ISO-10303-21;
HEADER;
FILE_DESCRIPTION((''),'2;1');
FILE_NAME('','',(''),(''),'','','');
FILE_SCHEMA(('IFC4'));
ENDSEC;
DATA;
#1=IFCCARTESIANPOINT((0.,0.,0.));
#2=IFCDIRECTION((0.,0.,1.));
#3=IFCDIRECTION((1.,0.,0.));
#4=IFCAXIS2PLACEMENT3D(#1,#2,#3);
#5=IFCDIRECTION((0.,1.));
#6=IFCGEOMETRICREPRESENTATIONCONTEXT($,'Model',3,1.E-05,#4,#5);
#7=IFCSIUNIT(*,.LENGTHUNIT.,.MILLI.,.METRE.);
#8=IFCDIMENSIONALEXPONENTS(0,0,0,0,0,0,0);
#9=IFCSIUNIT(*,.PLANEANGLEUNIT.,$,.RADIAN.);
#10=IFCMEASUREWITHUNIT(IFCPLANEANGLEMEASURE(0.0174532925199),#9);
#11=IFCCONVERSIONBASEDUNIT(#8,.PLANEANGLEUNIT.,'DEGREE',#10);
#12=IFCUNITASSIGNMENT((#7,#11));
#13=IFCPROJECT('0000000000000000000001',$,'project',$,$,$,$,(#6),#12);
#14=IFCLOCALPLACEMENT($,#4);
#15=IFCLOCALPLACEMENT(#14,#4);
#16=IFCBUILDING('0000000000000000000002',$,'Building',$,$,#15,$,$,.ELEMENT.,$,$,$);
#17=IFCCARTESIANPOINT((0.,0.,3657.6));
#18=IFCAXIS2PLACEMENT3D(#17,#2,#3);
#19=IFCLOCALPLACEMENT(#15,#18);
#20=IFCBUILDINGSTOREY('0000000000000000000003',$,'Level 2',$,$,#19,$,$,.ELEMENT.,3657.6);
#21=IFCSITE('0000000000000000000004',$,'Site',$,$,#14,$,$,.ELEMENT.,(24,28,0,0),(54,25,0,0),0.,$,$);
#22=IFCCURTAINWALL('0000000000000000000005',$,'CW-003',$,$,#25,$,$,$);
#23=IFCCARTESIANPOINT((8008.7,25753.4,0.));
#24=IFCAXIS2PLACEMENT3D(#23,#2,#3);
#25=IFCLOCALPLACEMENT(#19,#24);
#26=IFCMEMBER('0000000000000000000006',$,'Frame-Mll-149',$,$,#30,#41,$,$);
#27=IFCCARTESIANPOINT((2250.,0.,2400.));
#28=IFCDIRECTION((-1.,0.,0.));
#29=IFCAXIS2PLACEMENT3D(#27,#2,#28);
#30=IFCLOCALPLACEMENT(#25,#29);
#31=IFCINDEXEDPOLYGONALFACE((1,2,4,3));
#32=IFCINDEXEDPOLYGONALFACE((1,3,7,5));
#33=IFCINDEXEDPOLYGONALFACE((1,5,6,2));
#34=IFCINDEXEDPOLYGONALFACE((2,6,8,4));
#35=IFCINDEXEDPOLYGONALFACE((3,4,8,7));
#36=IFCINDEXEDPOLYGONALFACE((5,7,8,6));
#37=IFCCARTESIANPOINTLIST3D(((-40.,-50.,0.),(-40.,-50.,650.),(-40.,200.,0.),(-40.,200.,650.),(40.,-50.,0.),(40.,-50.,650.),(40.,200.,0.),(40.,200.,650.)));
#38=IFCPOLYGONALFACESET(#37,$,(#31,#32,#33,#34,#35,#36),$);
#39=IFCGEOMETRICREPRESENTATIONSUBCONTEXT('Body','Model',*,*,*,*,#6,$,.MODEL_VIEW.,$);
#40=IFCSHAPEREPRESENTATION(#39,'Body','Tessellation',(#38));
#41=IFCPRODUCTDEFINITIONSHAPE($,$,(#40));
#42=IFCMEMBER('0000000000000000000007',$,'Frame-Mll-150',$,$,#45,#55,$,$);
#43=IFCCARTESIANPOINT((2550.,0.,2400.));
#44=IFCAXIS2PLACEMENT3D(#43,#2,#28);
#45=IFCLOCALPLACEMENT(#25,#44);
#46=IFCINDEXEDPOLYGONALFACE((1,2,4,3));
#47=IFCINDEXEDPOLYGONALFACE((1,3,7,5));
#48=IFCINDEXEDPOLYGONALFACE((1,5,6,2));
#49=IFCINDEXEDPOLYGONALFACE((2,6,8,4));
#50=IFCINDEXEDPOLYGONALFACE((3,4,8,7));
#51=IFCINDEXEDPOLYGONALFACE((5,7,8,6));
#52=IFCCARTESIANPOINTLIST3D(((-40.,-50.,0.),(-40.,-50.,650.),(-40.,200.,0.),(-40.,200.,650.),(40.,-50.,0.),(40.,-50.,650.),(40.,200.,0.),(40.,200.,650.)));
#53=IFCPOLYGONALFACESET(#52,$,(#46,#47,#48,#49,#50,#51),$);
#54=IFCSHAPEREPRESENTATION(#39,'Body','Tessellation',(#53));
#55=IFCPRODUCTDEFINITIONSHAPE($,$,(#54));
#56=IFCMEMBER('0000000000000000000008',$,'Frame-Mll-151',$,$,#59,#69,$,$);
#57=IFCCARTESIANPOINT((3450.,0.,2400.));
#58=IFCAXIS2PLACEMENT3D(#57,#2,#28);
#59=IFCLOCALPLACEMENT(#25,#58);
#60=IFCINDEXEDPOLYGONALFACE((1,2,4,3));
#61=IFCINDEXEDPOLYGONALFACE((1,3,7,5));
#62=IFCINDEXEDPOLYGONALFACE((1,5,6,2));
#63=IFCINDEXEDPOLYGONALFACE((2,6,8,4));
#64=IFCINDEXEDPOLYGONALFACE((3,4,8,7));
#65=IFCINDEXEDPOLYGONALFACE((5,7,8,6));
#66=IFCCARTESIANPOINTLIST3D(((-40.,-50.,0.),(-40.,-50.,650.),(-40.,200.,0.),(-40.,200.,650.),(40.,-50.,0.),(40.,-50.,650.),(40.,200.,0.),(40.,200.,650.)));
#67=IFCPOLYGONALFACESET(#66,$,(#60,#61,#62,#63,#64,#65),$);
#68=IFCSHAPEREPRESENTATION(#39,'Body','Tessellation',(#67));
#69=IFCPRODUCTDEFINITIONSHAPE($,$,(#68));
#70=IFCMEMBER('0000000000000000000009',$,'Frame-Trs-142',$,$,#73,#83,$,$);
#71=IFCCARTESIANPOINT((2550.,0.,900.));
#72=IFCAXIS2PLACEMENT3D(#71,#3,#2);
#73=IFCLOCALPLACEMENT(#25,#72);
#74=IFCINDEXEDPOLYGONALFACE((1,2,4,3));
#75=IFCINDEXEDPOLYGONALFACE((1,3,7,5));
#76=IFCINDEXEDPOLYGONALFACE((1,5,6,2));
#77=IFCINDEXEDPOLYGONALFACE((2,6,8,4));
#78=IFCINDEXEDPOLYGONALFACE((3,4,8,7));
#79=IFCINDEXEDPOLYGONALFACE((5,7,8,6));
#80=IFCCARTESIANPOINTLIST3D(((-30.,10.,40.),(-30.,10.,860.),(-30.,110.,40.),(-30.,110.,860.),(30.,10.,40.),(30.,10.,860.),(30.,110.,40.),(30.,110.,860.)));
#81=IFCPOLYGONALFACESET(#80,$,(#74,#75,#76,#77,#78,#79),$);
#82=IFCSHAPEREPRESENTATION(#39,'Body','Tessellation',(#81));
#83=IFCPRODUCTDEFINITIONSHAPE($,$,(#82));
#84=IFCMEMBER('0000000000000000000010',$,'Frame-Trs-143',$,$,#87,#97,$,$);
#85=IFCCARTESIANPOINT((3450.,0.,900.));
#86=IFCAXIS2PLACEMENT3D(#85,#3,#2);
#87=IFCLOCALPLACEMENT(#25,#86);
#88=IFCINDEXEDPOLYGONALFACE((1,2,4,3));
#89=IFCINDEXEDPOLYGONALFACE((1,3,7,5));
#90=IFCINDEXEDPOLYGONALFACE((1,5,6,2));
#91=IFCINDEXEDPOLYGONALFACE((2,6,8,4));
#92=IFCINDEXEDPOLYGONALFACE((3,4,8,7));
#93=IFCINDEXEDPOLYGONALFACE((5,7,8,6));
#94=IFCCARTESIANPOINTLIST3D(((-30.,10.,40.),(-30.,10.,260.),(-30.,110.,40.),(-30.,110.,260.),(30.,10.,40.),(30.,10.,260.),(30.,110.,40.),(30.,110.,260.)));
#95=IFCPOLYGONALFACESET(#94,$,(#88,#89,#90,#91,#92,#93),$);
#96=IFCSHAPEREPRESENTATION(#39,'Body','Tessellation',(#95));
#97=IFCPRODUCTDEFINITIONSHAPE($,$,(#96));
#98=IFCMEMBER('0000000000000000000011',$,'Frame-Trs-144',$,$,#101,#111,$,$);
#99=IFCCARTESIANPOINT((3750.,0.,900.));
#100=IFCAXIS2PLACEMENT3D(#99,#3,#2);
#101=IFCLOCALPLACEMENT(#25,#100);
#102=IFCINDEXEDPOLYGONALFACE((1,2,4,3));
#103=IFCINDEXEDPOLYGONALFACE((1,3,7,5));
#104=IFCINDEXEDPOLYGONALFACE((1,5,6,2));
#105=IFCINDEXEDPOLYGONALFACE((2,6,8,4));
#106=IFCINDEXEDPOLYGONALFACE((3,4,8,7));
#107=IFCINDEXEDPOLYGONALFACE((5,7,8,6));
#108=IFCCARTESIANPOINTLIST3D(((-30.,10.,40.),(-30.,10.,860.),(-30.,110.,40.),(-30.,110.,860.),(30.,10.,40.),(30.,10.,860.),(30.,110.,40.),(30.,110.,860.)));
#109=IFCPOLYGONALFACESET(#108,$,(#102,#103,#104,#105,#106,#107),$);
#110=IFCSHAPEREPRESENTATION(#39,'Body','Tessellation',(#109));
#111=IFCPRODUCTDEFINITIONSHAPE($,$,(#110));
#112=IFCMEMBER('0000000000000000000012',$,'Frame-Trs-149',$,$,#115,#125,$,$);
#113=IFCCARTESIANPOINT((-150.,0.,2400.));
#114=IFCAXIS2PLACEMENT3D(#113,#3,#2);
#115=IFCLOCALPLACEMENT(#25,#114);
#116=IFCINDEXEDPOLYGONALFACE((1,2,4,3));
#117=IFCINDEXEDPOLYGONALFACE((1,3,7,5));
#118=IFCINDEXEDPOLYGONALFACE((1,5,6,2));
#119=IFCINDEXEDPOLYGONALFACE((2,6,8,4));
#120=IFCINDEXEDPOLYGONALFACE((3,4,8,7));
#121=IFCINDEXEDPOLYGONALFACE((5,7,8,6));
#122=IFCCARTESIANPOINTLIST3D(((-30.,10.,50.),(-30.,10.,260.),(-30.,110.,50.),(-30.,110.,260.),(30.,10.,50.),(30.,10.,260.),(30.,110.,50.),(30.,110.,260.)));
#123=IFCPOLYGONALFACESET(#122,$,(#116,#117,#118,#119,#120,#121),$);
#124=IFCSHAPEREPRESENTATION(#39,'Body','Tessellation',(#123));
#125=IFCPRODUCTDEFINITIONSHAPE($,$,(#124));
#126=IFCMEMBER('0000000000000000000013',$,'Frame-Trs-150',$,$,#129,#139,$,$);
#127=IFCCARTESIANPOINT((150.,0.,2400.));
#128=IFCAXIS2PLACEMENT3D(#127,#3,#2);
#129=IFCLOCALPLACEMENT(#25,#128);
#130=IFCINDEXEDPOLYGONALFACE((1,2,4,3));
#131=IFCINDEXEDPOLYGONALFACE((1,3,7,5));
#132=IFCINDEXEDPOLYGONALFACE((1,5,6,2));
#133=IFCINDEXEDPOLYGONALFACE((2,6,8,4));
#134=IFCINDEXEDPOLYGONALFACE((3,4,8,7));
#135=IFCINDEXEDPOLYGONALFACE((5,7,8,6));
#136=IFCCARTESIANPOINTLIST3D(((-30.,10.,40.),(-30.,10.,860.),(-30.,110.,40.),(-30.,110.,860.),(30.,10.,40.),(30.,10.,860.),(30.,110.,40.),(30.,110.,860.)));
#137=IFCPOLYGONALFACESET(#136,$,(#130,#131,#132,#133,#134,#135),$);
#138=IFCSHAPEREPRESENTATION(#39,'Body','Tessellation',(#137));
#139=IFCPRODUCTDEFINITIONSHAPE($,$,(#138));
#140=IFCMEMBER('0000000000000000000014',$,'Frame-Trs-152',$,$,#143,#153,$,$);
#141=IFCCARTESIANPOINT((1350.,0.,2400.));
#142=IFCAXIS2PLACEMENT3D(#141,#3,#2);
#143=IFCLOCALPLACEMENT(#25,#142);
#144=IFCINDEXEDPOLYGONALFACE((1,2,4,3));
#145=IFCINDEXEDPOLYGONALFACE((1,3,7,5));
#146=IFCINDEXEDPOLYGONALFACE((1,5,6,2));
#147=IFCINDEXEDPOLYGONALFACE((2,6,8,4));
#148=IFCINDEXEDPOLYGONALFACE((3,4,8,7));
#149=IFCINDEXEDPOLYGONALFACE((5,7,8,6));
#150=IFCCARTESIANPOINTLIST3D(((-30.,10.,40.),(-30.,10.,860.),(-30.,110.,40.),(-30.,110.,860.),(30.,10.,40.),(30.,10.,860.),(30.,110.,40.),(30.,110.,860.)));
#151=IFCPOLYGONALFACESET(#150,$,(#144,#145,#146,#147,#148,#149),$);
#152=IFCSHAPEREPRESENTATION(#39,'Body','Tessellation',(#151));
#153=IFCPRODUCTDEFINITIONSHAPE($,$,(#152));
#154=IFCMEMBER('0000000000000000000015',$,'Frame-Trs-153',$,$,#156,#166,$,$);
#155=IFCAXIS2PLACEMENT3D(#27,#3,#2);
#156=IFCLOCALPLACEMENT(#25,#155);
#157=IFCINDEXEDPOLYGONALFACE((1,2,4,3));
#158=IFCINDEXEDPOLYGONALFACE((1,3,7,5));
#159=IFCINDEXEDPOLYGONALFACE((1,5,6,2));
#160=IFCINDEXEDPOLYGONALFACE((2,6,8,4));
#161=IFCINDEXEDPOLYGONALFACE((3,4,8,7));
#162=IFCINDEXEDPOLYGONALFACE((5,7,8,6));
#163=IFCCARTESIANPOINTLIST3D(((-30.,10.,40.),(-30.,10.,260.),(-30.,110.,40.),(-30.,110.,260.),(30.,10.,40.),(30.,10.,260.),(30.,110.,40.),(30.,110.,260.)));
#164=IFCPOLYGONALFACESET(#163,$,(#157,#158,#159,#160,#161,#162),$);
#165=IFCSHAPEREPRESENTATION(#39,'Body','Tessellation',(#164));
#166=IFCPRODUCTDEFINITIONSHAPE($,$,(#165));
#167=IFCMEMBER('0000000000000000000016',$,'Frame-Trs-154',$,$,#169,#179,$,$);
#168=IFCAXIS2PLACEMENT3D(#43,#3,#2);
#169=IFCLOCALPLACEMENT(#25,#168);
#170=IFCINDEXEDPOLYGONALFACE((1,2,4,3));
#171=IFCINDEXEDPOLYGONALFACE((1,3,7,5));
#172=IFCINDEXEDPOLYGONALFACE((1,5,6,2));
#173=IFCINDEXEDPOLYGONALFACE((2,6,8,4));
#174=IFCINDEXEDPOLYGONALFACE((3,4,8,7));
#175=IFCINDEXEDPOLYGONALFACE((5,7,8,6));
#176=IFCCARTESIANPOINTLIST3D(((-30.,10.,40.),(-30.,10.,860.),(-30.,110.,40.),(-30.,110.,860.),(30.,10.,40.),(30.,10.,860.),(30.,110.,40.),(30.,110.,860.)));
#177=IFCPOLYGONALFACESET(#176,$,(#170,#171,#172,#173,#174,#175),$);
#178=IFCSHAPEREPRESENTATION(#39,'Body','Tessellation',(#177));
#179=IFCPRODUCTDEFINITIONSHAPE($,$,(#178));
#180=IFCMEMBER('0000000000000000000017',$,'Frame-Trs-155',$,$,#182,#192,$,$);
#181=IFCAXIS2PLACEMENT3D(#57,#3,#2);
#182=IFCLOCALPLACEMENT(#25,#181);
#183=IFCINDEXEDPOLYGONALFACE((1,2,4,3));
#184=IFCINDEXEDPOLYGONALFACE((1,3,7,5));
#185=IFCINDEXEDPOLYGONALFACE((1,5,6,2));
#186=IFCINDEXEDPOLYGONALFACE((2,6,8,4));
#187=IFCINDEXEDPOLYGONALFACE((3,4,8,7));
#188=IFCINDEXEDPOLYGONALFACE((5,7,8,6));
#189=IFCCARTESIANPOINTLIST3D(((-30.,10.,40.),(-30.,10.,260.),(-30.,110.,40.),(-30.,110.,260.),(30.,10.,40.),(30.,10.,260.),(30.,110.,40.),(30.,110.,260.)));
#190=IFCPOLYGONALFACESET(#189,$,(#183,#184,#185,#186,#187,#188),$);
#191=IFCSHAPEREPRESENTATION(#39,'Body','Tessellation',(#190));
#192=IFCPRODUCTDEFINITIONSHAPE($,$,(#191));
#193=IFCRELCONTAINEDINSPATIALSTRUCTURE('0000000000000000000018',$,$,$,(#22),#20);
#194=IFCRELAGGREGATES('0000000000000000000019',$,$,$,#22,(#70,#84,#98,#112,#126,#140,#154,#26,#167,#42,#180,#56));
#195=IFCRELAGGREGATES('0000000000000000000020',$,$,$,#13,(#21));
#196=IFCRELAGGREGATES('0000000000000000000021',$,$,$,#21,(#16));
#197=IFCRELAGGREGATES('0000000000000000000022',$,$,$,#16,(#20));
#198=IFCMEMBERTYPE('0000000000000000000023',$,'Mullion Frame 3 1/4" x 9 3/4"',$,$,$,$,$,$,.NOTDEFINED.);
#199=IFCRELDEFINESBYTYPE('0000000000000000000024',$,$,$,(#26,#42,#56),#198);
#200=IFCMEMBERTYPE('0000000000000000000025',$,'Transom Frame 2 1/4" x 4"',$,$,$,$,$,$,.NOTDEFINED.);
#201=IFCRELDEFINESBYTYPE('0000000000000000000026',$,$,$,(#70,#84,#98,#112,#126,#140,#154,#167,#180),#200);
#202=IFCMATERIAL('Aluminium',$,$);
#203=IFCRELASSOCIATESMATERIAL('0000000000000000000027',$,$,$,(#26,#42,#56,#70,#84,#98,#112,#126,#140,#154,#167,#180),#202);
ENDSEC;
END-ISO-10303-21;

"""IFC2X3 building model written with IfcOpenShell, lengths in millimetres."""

from ifc_helpers import new_model, entity, si_unit, converted_unit, direction, frame, origin_with_axes, place, context, subcontext, project, spatial, polyline, outline, extrude, material, type_object, element, aggregate, save


model = new_model("IFC2X3")

# Units and contexts
model_context = context("Model", 3, precision=1e-05, world=origin_with_axes(), true_north=direction((0.0, 1.0)))
body_context = subcontext(model_context, "Body", "Model", "MODEL_VIEW")
ifc_project = project(units=[si_unit("LENGTHUNIT", "METRE", prefix="MILLI"), converted_unit("PLANEANGLEUNIT", "DEGREE", entity("IfcPlaneAngleMeasure", 0.0174532925199), si_unit("PLANEANGLEUNIT", "RADIAN"), dimensions=[0, 0, 0, 0, 0, 0, 0])], contexts=[model_context])

# Site, building, storey
site_placement = place(None, origin_with_axes())
site = spatial("IfcSite", under=ifc_project, at=site_placement, Name="Site", CompositionType="ELEMENT", RefLatitude=(24, 28, 0, 0), RefLongitude=(54, 25, 0, 0), RefElevation=0.0)
building_placement = place(site_placement, origin_with_axes())
building = spatial("IfcBuilding", under=site, at=building_placement, Name="Building", CompositionType="ELEMENT")
storey_placement = place(building_placement, frame((0.0, 0.0, 3657.6), z_axis=(0.0, 0.0, 1.0), x_axis=(1.0, 0.0, 0.0)))
storey = spatial("IfcBuildingStorey", under=building, at=storey_placement, Name="Level 2", CompositionType="ELEMENT", Elevation=3657.6)

# Curtain wall, members
curtain_wall_placement = place(storey_placement, frame((8008.7, 25753.4, 0.0), z_axis=(0.0, 0.0, 1.0), x_axis=(1.0, 0.0, 0.0)))
curtain_wall = element("IfcCurtainWall", 1, at=curtain_wall_placement, inside=storey, Name="CW-003")
ifc_material_1 = material(Name="Aluminium")
member_type_1 = type_object("IfcMemberType", Name="Mullion Frame 3 1/4\" x 9 3/4\"", PredefinedType="NOTDEFINED")
member_1_placement = place(curtain_wall_placement, frame((2250.0, 0.0, 2400.0), z_axis=(0.0, 0.0, 1.0), x_axis=(-1.0, 0.0, 0.0)))
member_1 = element("IfcMember", 2, at=member_1_placement, type_object=member_type_1, material=ifc_material_1, Name="Frame-Mll-149", context=body_context, shape_type="SweptSolid", body=[
    extrude(outline(polyline([(-40.0, -200.0), (40.0, -200.0), (40.0, 50.0), (-40.0, 50.0), (-40.0, -200.0)])), frame((0.0, 0.0, 0.0), z_axis=(0.0, 0.0, 1.0), x_axis=(-1.0, 0.0, 0.0)), (0.0, 0.0, 1.0), 650.0),
])
member_2_placement = place(curtain_wall_placement, frame((2550.0, 0.0, 2400.0), z_axis=(0.0, 0.0, 1.0), x_axis=(-1.0, 0.0, 0.0)))
member_2 = element("IfcMember", 3, at=member_2_placement, type_object=member_type_1, material=ifc_material_1, Name="Frame-Mll-150", context=body_context, shape_type="SweptSolid", body=[
    extrude(outline(polyline([(-40.0, -200.0), (40.0, -200.0), (40.0, 50.0), (-40.0, 50.0), (-40.0, -200.0)])), frame((0.0, 0.0, 0.0), z_axis=(0.0, 0.0, 1.0), x_axis=(-1.0, 0.0, 0.0)), (0.0, 0.0, 1.0), 650.0),
])
member_3_placement = place(curtain_wall_placement, frame((3450.0, 0.0, 2400.0), z_axis=(0.0, 0.0, 1.0), x_axis=(-1.0, 0.0, 0.0)))
member_3 = element("IfcMember", 4, at=member_3_placement, type_object=member_type_1, material=ifc_material_1, Name="Frame-Mll-151", context=body_context, shape_type="SweptSolid", body=[
    extrude(outline(polyline([(-40.0, -200.0), (40.0, -200.0), (40.0, 50.0), (-40.0, 50.0), (-40.0, -200.0)])), frame((0.0, 0.0, 0.0), z_axis=(0.0, 0.0, 1.0), x_axis=(-1.0, 0.0, 0.0)), (0.0, 0.0, 1.0), 650.0),
])
member_type_2 = type_object("IfcMemberType", Name="Transom Frame 2 1/4\" x 4\"", PredefinedType="NOTDEFINED")
member_4_placement = place(curtain_wall_placement, frame((2550.0, 0.0, 900.0), z_axis=(1.0, 0.0, 0.0), x_axis=(0.0, 0.0, 1.0)))
member_4 = element("IfcMember", 5, at=member_4_placement, type_object=member_type_2, material=ifc_material_1, Name="Frame-Trs-142", context=body_context, shape_type="SweptSolid", body=[
    extrude(outline(polyline([(110.0, -30.0), (110.0, 30.0), (10.0, 30.0), (10.0, -30.0), (110.0, -30.0)])), frame((0.0, 0.0, 40.0), z_axis=(0.0, 0.0, 1.0), x_axis=(0.0, 1.0, 0.0)), (0.0, 0.0, 1.0), 820.0),
])
member_5_placement = place(curtain_wall_placement, frame((3450.0, 0.0, 900.0), z_axis=(1.0, 0.0, 0.0), x_axis=(0.0, 0.0, 1.0)))
member_5 = element("IfcMember", 6, at=member_5_placement, type_object=member_type_2, material=ifc_material_1, Name="Frame-Trs-143", context=body_context, shape_type="SweptSolid", body=[
    extrude(outline(polyline([(110.0, -30.0), (110.0, 30.0), (10.0, 30.0), (10.0, -30.0), (110.0, -30.0)])), frame((0.0, 0.0, 40.0), z_axis=(0.0, 0.0, 1.0), x_axis=(0.0, 1.0, 0.0)), (0.0, 0.0, 1.0), 220.0),
])
member_6_placement = place(curtain_wall_placement, frame((3750.0, 0.0, 900.0), z_axis=(1.0, 0.0, 0.0), x_axis=(0.0, 0.0, 1.0)))
member_6 = element("IfcMember", 7, at=member_6_placement, type_object=member_type_2, material=ifc_material_1, Name="Frame-Trs-144", context=body_context, shape_type="SweptSolid", body=[
    extrude(outline(polyline([(110.0, -30.0), (110.0, 30.0), (10.0, 30.0), (10.0, -30.0), (110.0, -30.0)])), frame((0.0, 0.0, 40.0), z_axis=(0.0, 0.0, 1.0), x_axis=(0.0, 1.0, 0.0)), (0.0, 0.0, 1.0), 820.0),
])
member_7_placement = place(curtain_wall_placement, frame((-150.0, 0.0, 2400.0), z_axis=(1.0, 0.0, 0.0), x_axis=(0.0, 0.0, 1.0)))
member_7 = element("IfcMember", 8, at=member_7_placement, type_object=member_type_2, material=ifc_material_1, Name="Frame-Trs-149", context=body_context, shape_type="SweptSolid", body=[
    extrude(outline(polyline([(110.0, -30.0), (110.0, 30.0), (10.0, 30.0), (10.0, -30.0), (110.0, -30.0)])), frame((0.0, 0.0, 50.0), z_axis=(0.0, 0.0, 1.0), x_axis=(0.0, 1.0, 0.0)), (0.0, 0.0, 1.0), 210.0),
])
member_8_placement = place(curtain_wall_placement, frame((150.0, 0.0, 2400.0), z_axis=(1.0, 0.0, 0.0), x_axis=(0.0, 0.0, 1.0)))
member_8 = element("IfcMember", 9, at=member_8_placement, type_object=member_type_2, material=ifc_material_1, Name="Frame-Trs-150", context=body_context, shape_type="SweptSolid", body=[
    extrude(outline(polyline([(110.0, -30.0), (110.0, 30.0), (10.0, 30.0), (10.0, -30.0), (110.0, -30.0)])), frame((0.0, 0.0, 40.0), z_axis=(0.0, 0.0, 1.0), x_axis=(0.0, 1.0, 0.0)), (0.0, 0.0, 1.0), 820.0),
])
member_9_placement = place(curtain_wall_placement, frame((1350.0, 0.0, 2400.0), z_axis=(1.0, 0.0, 0.0), x_axis=(0.0, 0.0, 1.0)))
member_9 = element("IfcMember", 10, at=member_9_placement, type_object=member_type_2, material=ifc_material_1, Name="Frame-Trs-152", context=body_context, shape_type="SweptSolid", body=[
    extrude(outline(polyline([(110.0, -30.0), (110.0, 30.0), (10.0, 30.0), (10.0, -30.0), (110.0, -30.0)])), frame((0.0, 0.0, 40.0), z_axis=(0.0, 0.0, 1.0), x_axis=(0.0, 1.0, 0.0)), (0.0, 0.0, 1.0), 820.0),
])
member_10_placement = place(curtain_wall_placement, frame((2250.0, 0.0, 2400.0), z_axis=(1.0, 0.0, 0.0), x_axis=(0.0, 0.0, 1.0)))
member_10 = element("IfcMember", 11, at=member_10_placement, type_object=member_type_2, material=ifc_material_1, Name="Frame-Trs-153", context=body_context, shape_type="SweptSolid", body=[
    extrude(outline(polyline([(110.0, -30.0), (110.0, 30.0), (10.0, 30.0), (10.0, -30.0), (110.0, -30.0)])), frame((0.0, 0.0, 40.0), z_axis=(0.0, 0.0, 1.0), x_axis=(0.0, 1.0, 0.0)), (0.0, 0.0, 1.0), 220.0),
])
member_11_placement = place(curtain_wall_placement, frame((2550.0, 0.0, 2400.0), z_axis=(1.0, 0.0, 0.0), x_axis=(0.0, 0.0, 1.0)))
member_11 = element("IfcMember", 12, at=member_11_placement, type_object=member_type_2, material=ifc_material_1, Name="Frame-Trs-154", context=body_context, shape_type="SweptSolid", body=[
    extrude(outline(polyline([(110.0, -30.0), (110.0, 30.0), (10.0, 30.0), (10.0, -30.0), (110.0, -30.0)])), frame((0.0, 0.0, 40.0), z_axis=(0.0, 0.0, 1.0), x_axis=(0.0, 1.0, 0.0)), (0.0, 0.0, 1.0), 820.0),
])
member_12_placement = place(curtain_wall_placement, frame((3450.0, 0.0, 2400.0), z_axis=(1.0, 0.0, 0.0), x_axis=(0.0, 0.0, 1.0)))
member_12 = element("IfcMember", 13, at=member_12_placement, type_object=member_type_2, material=ifc_material_1, Name="Frame-Trs-155", context=body_context, shape_type="SweptSolid", body=[
    extrude(outline(polyline([(110.0, -30.0), (110.0, 30.0), (10.0, 30.0), (10.0, -30.0), (110.0, -30.0)])), frame((0.0, 0.0, 40.0), z_axis=(0.0, 0.0, 1.0), x_axis=(0.0, 1.0, 0.0)), (0.0, 0.0, 1.0), 220.0),
])
aggregate(curtain_wall, [member_4, member_5, member_6, member_7, member_8, member_9, member_10, member_1, member_11, member_2, member_12, member_3])

save(model, "model.ifc")
